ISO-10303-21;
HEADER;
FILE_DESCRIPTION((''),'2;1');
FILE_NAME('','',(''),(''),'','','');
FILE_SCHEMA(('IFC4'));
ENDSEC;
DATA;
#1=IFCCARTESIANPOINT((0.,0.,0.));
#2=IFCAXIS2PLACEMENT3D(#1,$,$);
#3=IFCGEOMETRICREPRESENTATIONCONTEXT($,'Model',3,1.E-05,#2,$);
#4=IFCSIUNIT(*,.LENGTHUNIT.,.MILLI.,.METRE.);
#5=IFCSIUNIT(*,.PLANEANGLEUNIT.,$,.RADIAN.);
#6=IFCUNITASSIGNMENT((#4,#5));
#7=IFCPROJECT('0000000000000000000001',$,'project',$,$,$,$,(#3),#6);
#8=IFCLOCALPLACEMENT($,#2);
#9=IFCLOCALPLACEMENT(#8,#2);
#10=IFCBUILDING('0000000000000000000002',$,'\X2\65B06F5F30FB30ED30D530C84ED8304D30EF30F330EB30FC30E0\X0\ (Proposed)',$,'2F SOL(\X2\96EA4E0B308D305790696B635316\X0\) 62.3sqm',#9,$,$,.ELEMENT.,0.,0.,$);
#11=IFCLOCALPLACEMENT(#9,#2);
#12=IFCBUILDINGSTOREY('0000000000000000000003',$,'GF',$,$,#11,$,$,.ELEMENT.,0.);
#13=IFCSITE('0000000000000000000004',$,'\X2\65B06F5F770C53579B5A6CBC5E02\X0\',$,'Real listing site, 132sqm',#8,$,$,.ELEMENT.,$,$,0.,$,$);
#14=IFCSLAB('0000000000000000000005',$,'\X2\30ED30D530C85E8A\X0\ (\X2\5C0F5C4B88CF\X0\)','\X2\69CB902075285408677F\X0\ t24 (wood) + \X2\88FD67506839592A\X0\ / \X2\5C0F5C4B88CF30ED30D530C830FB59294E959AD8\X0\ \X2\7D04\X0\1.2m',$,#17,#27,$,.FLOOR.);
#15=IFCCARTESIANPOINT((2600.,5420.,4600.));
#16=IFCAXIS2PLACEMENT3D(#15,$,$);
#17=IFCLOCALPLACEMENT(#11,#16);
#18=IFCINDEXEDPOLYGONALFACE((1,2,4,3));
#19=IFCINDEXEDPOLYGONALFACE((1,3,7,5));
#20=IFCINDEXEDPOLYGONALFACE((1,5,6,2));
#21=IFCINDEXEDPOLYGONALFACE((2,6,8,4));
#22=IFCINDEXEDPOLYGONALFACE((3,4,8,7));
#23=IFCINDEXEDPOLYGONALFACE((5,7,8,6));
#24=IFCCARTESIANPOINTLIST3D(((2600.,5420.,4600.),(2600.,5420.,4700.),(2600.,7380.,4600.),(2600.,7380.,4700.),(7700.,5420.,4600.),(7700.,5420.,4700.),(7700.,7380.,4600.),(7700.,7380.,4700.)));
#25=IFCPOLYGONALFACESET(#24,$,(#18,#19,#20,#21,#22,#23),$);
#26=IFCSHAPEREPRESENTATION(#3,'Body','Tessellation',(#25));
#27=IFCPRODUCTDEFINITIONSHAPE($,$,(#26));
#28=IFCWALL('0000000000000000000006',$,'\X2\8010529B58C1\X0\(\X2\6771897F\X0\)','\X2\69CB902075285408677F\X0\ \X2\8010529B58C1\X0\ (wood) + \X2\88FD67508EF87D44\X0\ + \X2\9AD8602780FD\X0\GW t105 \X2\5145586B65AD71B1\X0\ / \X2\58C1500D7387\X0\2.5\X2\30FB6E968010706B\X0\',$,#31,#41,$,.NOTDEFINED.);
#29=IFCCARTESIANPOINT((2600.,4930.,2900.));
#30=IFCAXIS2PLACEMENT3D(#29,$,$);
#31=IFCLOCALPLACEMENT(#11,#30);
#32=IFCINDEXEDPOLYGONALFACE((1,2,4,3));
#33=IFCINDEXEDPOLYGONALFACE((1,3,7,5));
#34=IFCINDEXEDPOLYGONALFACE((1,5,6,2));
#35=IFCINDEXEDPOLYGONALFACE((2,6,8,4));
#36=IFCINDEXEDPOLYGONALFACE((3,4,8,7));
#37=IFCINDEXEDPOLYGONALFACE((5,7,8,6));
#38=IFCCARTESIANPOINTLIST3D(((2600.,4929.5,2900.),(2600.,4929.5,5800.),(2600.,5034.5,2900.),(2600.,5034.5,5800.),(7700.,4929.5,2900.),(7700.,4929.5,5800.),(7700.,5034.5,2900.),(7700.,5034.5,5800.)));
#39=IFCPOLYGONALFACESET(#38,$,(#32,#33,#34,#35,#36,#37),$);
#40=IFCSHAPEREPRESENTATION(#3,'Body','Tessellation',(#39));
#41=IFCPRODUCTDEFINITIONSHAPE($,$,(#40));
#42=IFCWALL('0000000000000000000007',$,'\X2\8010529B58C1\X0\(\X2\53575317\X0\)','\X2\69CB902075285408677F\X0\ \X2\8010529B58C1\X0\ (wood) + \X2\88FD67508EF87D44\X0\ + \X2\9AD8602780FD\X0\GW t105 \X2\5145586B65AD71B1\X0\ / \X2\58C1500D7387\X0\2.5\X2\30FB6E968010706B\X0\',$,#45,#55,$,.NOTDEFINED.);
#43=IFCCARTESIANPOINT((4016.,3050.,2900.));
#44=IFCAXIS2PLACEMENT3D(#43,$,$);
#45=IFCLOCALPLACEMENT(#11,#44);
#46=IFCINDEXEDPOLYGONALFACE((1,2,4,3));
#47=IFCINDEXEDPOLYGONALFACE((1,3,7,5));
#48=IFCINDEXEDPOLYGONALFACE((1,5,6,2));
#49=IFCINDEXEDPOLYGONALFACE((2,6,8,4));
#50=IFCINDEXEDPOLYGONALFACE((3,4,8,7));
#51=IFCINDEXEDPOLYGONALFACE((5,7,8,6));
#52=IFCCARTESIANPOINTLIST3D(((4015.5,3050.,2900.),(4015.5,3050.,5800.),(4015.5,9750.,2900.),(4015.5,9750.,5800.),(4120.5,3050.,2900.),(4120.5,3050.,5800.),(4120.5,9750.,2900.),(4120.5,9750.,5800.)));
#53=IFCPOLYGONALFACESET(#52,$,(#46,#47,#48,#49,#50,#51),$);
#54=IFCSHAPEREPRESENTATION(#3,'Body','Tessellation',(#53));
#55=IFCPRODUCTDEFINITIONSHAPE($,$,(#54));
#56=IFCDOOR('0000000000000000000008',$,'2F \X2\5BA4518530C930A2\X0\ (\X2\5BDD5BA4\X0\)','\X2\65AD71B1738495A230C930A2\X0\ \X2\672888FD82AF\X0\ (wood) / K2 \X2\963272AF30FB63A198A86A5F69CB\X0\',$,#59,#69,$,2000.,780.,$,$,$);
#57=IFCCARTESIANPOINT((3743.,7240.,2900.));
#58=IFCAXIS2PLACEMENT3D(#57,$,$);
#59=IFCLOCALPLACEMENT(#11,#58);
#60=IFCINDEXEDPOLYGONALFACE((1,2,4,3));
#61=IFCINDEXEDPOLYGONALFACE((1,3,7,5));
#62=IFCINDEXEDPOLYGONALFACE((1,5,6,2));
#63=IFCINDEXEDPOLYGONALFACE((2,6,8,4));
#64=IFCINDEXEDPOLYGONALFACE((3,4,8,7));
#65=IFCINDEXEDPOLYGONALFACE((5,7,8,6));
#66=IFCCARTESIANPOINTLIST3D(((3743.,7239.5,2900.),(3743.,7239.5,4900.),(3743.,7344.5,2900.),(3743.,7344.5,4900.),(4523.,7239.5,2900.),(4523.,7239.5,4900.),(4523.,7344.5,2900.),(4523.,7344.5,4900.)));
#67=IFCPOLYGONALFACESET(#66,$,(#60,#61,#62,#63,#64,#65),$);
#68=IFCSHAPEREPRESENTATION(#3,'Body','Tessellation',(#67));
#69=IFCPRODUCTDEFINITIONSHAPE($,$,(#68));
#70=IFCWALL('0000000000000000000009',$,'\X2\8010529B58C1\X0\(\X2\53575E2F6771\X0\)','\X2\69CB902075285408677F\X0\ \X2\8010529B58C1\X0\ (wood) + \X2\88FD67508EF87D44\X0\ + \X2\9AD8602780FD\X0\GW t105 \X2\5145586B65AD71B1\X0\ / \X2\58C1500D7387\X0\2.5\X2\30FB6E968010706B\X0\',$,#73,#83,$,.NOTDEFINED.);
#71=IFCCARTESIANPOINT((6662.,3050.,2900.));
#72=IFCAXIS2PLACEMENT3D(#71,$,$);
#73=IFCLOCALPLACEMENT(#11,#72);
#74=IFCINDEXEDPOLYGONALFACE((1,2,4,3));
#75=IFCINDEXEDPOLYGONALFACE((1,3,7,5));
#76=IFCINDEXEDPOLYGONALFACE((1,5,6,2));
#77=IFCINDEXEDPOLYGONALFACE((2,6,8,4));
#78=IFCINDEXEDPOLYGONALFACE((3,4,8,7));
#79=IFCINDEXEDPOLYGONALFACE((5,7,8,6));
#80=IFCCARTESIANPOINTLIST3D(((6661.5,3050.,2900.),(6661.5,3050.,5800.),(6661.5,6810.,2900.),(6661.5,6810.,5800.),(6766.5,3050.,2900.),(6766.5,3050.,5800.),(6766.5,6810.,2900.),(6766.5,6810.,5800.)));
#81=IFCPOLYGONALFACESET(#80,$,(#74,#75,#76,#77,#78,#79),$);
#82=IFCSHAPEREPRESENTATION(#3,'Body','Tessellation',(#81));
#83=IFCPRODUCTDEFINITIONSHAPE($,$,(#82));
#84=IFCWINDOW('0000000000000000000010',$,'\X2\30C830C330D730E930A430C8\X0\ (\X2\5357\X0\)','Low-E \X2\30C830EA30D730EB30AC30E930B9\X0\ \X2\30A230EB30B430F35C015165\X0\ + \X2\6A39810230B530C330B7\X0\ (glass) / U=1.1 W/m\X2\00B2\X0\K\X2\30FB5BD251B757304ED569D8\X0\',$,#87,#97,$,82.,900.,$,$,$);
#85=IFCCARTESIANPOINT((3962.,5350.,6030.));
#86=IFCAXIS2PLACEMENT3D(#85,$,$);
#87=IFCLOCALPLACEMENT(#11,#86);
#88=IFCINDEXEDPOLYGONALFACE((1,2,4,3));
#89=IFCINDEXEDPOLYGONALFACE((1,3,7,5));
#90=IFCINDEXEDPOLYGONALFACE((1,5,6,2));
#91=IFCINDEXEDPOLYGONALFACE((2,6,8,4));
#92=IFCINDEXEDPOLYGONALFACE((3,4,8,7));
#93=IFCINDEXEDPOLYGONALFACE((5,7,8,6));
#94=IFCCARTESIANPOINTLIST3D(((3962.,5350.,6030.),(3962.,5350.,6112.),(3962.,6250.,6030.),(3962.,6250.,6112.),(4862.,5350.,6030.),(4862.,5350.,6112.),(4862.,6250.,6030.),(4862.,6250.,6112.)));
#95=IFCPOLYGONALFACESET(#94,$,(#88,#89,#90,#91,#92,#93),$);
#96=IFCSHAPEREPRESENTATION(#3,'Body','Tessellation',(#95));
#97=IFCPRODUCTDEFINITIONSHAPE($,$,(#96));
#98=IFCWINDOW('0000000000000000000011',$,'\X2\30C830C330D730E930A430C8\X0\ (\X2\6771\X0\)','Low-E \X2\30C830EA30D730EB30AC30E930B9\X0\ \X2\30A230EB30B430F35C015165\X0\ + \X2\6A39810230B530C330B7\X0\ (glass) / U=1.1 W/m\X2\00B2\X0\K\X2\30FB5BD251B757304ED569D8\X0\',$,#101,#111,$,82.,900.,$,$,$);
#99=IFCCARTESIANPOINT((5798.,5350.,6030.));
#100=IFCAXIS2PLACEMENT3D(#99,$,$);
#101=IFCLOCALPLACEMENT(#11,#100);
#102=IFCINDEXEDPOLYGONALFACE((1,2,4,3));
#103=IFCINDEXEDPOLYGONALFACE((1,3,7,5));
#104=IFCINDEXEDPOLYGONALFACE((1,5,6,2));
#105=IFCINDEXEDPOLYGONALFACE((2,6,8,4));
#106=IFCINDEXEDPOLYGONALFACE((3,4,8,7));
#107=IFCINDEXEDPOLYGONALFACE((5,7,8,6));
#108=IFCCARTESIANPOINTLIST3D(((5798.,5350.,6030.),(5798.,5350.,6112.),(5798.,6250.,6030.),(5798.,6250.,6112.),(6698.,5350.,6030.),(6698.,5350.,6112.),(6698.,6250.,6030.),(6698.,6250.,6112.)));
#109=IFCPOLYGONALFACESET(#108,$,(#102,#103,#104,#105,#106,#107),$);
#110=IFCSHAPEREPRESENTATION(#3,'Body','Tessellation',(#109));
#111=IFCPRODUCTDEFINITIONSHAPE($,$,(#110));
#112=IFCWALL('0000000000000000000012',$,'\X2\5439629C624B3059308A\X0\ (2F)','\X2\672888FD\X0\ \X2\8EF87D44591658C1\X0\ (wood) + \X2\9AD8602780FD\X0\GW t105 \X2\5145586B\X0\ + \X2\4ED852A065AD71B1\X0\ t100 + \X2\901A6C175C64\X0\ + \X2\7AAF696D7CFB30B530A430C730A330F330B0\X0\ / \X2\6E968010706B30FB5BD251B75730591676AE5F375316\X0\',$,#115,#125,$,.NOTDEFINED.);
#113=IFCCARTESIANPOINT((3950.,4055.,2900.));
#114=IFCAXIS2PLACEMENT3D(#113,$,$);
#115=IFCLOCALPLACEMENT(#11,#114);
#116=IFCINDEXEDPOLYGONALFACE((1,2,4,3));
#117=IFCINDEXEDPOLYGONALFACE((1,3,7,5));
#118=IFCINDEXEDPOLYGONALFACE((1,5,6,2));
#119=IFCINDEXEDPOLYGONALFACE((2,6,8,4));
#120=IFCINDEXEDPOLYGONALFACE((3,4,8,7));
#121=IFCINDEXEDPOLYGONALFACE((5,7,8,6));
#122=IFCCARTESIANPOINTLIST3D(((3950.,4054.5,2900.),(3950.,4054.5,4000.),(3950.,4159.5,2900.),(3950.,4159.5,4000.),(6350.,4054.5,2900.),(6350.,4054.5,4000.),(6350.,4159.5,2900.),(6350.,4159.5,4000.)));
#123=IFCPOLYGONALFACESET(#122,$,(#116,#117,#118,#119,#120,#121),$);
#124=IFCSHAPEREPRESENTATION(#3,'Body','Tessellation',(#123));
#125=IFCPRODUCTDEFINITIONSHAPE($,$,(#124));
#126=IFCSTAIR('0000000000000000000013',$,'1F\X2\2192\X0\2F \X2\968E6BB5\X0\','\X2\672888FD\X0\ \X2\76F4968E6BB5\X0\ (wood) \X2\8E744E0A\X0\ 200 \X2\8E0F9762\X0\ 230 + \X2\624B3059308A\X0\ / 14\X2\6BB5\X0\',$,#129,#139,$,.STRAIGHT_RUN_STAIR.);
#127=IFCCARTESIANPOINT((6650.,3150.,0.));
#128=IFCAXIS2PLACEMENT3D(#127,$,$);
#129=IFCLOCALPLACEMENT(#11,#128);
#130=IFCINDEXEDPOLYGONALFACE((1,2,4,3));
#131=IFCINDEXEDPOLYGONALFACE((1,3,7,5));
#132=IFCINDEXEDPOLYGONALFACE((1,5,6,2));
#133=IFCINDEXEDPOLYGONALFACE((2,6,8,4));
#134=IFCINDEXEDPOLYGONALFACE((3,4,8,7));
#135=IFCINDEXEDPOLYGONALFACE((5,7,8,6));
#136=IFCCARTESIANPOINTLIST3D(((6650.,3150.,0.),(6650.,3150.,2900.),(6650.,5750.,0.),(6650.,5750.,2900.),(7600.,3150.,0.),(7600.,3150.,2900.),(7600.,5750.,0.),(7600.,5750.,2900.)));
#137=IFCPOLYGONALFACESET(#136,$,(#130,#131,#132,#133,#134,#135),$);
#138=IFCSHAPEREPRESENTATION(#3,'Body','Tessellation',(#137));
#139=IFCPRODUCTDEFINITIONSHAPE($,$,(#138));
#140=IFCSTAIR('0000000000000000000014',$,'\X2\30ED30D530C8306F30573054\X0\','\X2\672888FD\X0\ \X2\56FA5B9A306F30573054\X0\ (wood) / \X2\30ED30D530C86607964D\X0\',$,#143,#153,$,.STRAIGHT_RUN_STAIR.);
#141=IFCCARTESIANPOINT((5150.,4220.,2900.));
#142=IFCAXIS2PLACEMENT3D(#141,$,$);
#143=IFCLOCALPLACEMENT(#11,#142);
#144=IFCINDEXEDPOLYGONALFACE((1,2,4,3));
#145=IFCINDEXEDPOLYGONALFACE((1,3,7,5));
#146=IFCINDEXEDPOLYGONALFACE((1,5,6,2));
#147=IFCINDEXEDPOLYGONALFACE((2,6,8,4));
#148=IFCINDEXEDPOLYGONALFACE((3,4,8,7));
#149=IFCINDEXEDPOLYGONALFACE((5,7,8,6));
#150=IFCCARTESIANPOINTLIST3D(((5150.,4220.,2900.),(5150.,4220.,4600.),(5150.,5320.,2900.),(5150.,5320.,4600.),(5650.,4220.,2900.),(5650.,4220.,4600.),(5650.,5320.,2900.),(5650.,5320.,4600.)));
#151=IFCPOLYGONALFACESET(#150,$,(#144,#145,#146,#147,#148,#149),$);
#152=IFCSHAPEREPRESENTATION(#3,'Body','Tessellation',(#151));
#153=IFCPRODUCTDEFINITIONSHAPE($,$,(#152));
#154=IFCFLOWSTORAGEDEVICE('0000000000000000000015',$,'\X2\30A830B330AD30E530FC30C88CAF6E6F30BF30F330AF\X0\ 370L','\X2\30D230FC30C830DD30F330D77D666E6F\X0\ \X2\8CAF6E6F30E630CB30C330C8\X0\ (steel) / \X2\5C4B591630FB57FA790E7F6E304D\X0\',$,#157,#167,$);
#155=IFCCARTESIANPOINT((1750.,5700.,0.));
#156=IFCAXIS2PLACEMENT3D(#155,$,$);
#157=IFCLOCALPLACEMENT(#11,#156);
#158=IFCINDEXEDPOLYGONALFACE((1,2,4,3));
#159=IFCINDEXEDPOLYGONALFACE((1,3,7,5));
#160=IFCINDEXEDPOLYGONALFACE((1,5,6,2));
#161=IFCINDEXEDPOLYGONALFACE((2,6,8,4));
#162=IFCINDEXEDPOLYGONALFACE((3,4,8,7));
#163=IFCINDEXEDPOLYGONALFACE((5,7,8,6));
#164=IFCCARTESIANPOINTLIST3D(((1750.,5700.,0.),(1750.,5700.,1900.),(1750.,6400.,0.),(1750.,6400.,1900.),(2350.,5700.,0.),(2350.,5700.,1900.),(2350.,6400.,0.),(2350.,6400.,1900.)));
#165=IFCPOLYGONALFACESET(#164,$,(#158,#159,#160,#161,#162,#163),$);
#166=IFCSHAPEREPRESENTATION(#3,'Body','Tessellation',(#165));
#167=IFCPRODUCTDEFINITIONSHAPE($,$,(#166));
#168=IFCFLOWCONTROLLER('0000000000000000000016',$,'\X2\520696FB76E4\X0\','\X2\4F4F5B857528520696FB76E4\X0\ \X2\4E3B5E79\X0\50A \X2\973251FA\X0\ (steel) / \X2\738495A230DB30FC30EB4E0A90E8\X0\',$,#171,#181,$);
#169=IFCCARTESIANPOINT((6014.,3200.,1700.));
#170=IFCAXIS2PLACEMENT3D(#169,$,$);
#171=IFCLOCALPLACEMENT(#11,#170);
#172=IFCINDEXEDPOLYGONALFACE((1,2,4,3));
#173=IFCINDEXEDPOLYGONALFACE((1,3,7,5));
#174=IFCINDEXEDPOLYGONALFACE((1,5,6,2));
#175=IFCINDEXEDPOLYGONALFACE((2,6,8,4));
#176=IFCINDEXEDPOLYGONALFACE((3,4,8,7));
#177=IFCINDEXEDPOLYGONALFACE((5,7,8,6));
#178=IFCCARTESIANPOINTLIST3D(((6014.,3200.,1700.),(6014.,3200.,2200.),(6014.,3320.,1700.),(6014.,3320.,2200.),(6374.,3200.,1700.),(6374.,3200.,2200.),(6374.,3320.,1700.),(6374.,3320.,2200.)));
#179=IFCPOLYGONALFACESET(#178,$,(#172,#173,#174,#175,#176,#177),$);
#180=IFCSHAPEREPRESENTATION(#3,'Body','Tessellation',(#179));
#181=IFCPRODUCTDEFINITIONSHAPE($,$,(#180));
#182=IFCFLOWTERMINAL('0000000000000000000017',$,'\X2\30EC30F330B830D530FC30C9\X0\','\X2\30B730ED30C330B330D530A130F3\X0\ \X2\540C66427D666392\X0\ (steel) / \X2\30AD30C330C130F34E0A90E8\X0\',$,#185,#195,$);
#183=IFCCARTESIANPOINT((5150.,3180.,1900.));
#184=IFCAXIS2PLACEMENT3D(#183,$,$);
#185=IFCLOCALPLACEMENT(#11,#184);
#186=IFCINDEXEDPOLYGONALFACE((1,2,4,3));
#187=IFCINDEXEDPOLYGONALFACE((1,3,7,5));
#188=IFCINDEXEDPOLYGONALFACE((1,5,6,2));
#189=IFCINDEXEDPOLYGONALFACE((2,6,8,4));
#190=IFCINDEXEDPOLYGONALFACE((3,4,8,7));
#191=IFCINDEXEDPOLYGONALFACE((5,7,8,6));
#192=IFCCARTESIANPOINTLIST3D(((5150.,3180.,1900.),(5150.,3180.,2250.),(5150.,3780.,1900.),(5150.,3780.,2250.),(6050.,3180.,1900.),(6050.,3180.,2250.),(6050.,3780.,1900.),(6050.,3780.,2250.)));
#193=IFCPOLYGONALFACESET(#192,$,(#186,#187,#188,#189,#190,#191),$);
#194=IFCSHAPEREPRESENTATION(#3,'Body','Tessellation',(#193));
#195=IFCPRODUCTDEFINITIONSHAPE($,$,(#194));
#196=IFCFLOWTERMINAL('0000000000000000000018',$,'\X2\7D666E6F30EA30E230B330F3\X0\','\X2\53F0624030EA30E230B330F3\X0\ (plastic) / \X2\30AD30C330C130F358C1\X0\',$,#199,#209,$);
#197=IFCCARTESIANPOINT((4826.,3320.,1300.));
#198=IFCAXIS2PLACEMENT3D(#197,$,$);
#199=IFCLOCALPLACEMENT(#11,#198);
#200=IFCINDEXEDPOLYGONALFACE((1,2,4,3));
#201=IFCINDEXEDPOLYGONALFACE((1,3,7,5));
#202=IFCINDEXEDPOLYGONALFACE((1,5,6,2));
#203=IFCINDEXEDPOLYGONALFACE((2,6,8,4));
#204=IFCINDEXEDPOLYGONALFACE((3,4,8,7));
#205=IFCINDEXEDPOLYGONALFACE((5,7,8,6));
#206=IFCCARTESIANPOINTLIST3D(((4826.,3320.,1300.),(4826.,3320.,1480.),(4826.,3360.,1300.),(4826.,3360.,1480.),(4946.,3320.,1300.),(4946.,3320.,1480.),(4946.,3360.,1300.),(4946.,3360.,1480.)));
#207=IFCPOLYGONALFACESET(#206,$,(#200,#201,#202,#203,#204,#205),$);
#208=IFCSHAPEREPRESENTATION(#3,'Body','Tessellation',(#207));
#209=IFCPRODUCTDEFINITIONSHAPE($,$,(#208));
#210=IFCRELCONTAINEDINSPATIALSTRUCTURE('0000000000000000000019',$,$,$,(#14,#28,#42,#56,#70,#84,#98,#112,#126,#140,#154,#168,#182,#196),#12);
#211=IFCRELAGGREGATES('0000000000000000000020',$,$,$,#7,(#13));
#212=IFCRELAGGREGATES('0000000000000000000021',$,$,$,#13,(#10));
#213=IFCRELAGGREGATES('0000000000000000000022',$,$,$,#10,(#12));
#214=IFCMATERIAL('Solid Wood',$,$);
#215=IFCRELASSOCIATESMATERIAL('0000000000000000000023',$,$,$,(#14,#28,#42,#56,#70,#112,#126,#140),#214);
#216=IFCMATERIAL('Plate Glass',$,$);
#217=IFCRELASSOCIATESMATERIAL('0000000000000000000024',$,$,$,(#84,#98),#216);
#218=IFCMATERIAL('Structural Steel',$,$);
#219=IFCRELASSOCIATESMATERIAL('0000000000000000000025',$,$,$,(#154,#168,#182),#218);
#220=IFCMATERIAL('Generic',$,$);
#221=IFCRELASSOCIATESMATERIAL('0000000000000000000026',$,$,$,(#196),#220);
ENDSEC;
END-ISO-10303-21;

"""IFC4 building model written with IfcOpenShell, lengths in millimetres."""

from ifc_helpers import new_model, si_unit, frame, frame_2d, origin, place, context, project, spatial, rectangle, extrude, material, element, fill, save


model = new_model("IFC4")

# Units and contexts
model_context = context("Model", 3, precision=1e-05, world=origin())
ifc_project = project(units=[si_unit("LENGTHUNIT", "METRE", prefix="MILLI"), si_unit("PLANEANGLEUNIT", "RADIAN")], contexts=[model_context])

# Site, building, storey
site_placement = place(None, origin())
site = spatial("IfcSite", under=ifc_project, at=site_placement, Name="新潟県南魚沼市", ObjectType="Real listing site, 132sqm", CompositionType="ELEMENT", RefElevation=0.0)
building_placement = place(site_placement, origin())
building = spatial("IfcBuilding", under=site, at=building_placement, Name="新潟・ロフト付きワンルーム (Proposed)", ObjectType="2F SOL(雪下ろし適正化) 62.3sqm", CompositionType="ELEMENT", ElevationOfRefHeight=0.0, ElevationOfTerrain=0.0)
storey_placement = place(building_placement, origin())
storey = spatial("IfcBuildingStorey", under=building, at=storey_placement, Name="GF", CompositionType="ELEMENT", Elevation=0.0)

# Shared definitions
ifc_material_1 = material(Name="Solid Wood")

# Slab
slab_placement = place(storey_placement, frame((2600.0, 5420.0, 4600.0)))
element("IfcSlab", 1, at=slab_placement, inside=storey, material=ifc_material_1, Name="ロフト床 (小屋裏)", Description="構造用合板 t24 (wood) + 製材根太 / 小屋裏ロフト・天井高 約1.2m", PredefinedType="FLOOR", context=model_context, shape_type="SweptSolid", body=[
    extrude(rectangle(XDim=5100.0, YDim=1960.0, at=frame_2d((2550.0, 980.0))), frame((2600.0, 5420.0, 4600.0)), (0.0, 0.0, 1.0), 100.0),
])

# Wall
wall_1_placement = place(storey_placement, frame((2600.0, 4930.0, 2900.0)))
element("IfcWall", 2, at=wall_1_placement, inside=storey, material=ifc_material_1, Name="耐力壁(東西)", Description="構造用合板 耐力壁 (wood) + 製材軸組 + 高性能GW t105 充填断熱 / 壁倍率2.5・準耐火", PredefinedType="NOTDEFINED", context=model_context, shape_type="SweptSolid", body=[
    extrude(rectangle(XDim=5100.0, YDim=105.0, at=frame_2d((2550.0, 52.0))), frame((2600.0, 4930.0, 2900.0)), (0.0, 0.0, 1.0), 2900.0),
])

# Wall, opening, door
wall_2_placement = place(storey_placement, frame((4016.0, 3050.0, 2900.0)))
wall_2 = element("IfcWall", 3, at=wall_2_placement, inside=storey, material=ifc_material_1, Name="耐力壁(南北)", Description="構造用合板 耐力壁 (wood) + 製材軸組 + 高性能GW t105 充填断熱 / 壁倍率2.5・準耐火", PredefinedType="NOTDEFINED", context=model_context, shape_type="SweptSolid", body=[
    extrude(rectangle(XDim=105.0, YDim=6700.0, at=frame_2d((52.0, 3350.0))), frame((4016.0, 3050.0, 2900.0)), (0.0, 0.0, 1.0), 2900.0),
])
opening_placement = place(storey_placement, frame((3743.0, 7240.0, 2900.0)))
opening = element("IfcOpeningElement", 4, at=opening_placement, cuts=wall_2, PredefinedType="NOTDEFINED", context=model_context, shape_type="SweptSolid", body=[
    extrude(rectangle(XDim=780.0, YDim=105.0, at=frame_2d((390.0, 52.0))), frame((3743.0, 7240.0, 2900.0)), (0.0, 0.0, 1.0), 2000.0),
])
door_placement = place(storey_placement, frame((3743.0, 7240.0, 2900.0)))
door = element("IfcDoor", 5, at=door_placement, inside=storey, material=ifc_material_1, Name="2F 室内ドア (寝室)", Description="断熱玄関ドア 木製芯 (wood) / K2 防犯・採風機構", OverallHeight=2000.0, OverallWidth=780.0, context=model_context, shape_type="SweptSolid", body=[
    extrude(rectangle(XDim=780.0, YDim=105.0, at=frame_2d((390.0, 52.0))), frame((3743.0, 7240.0, 2900.0)), (0.0, 0.0, 1.0), 2000.0),
])
fill(opening, door)

# Wall
wall_3_placement = place(storey_placement, frame((6662.0, 3050.0, 2900.0)))
element("IfcWall", 6, at=wall_3_placement, inside=storey, material=ifc_material_1, Name="耐力壁(南帯東)", Description="構造用合板 耐力壁 (wood) + 製材軸組 + 高性能GW t105 充填断熱 / 壁倍率2.5・準耐火", PredefinedType="NOTDEFINED", context=model_context, shape_type="SweptSolid", body=[
    extrude(rectangle(XDim=105.0, YDim=3760.0, at=frame_2d((52.0, 1880.0))), frame((6662.0, 3050.0, 2900.0)), (0.0, 0.0, 1.0), 2900.0),
])

# Windows
ifc_material_2 = material(Name="Plate Glass")
window_1_placement = place(storey_placement, frame((3962.0, 5350.0, 6030.0)))
element("IfcWindow", 7, at=window_1_placement, inside=storey, material=ifc_material_2, Name="トップライト (南)", Description="Low-E トリプルガラス アルゴン封入 + 樹脂サッシ (glass) / U=1.1 W/m²K・寒冷地仕様", OverallHeight=82.0, OverallWidth=900.0, context=model_context, shape_type="SweptSolid", body=[
    extrude(rectangle(XDim=900.0, YDim=900.0, at=frame_2d((450.0, 450.0))), frame((3962.0, 5350.0, 6030.0)), (0.0, 0.0, 1.0), 82.0),
])
window_2_placement = place(storey_placement, frame((5798.0, 5350.0, 6030.0)))
element("IfcWindow", 8, at=window_2_placement, inside=storey, material=ifc_material_2, Name="トップライト (東)", Description="Low-E トリプルガラス アルゴン封入 + 樹脂サッシ (glass) / U=1.1 W/m²K・寒冷地仕様", OverallHeight=82.0, OverallWidth=900.0, context=model_context, shape_type="SweptSolid", body=[
    extrude(rectangle(XDim=900.0, YDim=900.0, at=frame_2d((450.0, 450.0))), frame((5798.0, 5350.0, 6030.0)), (0.0, 0.0, 1.0), 82.0),
])

# Wall
wall_4_placement = place(storey_placement, frame((3950.0, 4055.0, 2900.0)))
element("IfcWall", 9, at=wall_4_placement, inside=storey, material=ifc_material_1, Name="吹抜手すり (2F)", Description="木製 軸組外壁 (wood) + 高性能GW t105 充填 + 付加断熱 t100 + 通気層 + 窯業系サイディング / 準耐火・寒冷地外皮強化", PredefinedType="NOTDEFINED", context=model_context, shape_type="SweptSolid", body=[
    extrude(rectangle(XDim=2400.0, YDim=105.0, at=frame_2d((1200.0, 52.0))), frame((3950.0, 4055.0, 2900.0)), (0.0, 0.0, 1.0), 1100.0),
])

# Stairs
stair_1_placement = place(storey_placement, frame((6650.0, 3150.0, 0.0)))
element("IfcStair", 10, at=stair_1_placement, inside=storey, material=ifc_material_1, Name="1F→2F 階段", Description="木製 直階段 (wood) 蹴上 200 踏面 230 + 手すり / 14段", PredefinedType="STRAIGHT_RUN_STAIR", context=model_context, shape_type="SweptSolid", body=[
    extrude(rectangle(XDim=950.0, YDim=2600.0, at=frame_2d((475.0, 1300.0))), frame((6650.0, 3150.0, 0.0)), (0.0, 0.0, 1.0), 2900.0),
])
stair_2_placement = place(storey_placement, frame((5150.0, 4220.0, 2900.0)))
element("IfcStair", 11, at=stair_2_placement, inside=storey, material=ifc_material_1, Name="ロフトはしご", Description="木製 固定はしご (wood) / ロフト昇降", PredefinedType="STRAIGHT_RUN_STAIR", context=model_context, shape_type="SweptSolid", body=[
    extrude(rectangle(XDim=500.0, YDim=1100.0, at=frame_2d((250.0, 550.0))), frame((5150.0, 4220.0, 2900.0)), (0.0, 0.0, 1.0), 1700.0),
])

# Flow storage device
ifc_material_3 = material(Name="Structural Steel")
flow_storage_device_placement = place(storey_placement, frame((1750.0, 5700.0, 0.0)))
element("IfcFlowStorageDevice", 12, at=flow_storage_device_placement, inside=storey, material=ifc_material_3, Name="エコキュート貯湯タンク 370L", Description="ヒートポンプ給湯 貯湯ユニット (steel) / 屋外・基礎置き", context=model_context, shape_type="SweptSolid", body=[
    extrude(rectangle(XDim=600.0, YDim=700.0, at=frame_2d((300.0, 350.0))), frame((1750.0, 5700.0, 0.0)), (0.0, 0.0, 1.0), 1900.0),
])

# Flow controller
flow_controller_placement = place(storey_placement, frame((6014.0, 3200.0, 1700.0)))
element("IfcFlowController", 13, at=flow_controller_placement, inside=storey, material=ifc_material_3, Name="分電盤", Description="住宅用分電盤 主幹50A 露出 (steel) / 玄関ホール上部", context=model_context, shape_type="SweptSolid", body=[
    extrude(rectangle(XDim=360.0, YDim=120.0, at=frame_2d((180.0, 60.0))), frame((6014.0, 3200.0, 1700.0)), (0.0, 0.0, 1.0), 500.0),
])

# Flow terminals
flow_terminal_1_placement = place(storey_placement, frame((5150.0, 3180.0, 1900.0)))
element("IfcFlowTerminal", 14, at=flow_terminal_1_placement, inside=storey, material=ifc_material_3, Name="レンジフード", Description="シロッコファン 同時給排 (steel) / キッチン上部", context=model_context, shape_type="SweptSolid", body=[
    extrude(rectangle(XDim=900.0, YDim=600.0, at=frame_2d((450.0, 300.0))), frame((5150.0, 3180.0, 1900.0)), (0.0, 0.0, 1.0), 350.0),
])
ifc_material_4 = material(Name="Generic")
flow_terminal_2_placement = place(storey_placement, frame((4826.0, 3320.0, 1300.0)))
element("IfcFlowTerminal", 15, at=flow_terminal_2_placement, inside=storey, material=ifc_material_4, Name="給湯リモコン", Description="台所リモコン (plastic) / キッチン壁", context=model_context, shape_type="SweptSolid", body=[
    extrude(rectangle(XDim=120.0, YDim=40.0, at=frame_2d((60.0, 20.0))), frame((4826.0, 3320.0, 1300.0)), (0.0, 0.0, 1.0), 180.0),
])

save(model, "model.ifc")
